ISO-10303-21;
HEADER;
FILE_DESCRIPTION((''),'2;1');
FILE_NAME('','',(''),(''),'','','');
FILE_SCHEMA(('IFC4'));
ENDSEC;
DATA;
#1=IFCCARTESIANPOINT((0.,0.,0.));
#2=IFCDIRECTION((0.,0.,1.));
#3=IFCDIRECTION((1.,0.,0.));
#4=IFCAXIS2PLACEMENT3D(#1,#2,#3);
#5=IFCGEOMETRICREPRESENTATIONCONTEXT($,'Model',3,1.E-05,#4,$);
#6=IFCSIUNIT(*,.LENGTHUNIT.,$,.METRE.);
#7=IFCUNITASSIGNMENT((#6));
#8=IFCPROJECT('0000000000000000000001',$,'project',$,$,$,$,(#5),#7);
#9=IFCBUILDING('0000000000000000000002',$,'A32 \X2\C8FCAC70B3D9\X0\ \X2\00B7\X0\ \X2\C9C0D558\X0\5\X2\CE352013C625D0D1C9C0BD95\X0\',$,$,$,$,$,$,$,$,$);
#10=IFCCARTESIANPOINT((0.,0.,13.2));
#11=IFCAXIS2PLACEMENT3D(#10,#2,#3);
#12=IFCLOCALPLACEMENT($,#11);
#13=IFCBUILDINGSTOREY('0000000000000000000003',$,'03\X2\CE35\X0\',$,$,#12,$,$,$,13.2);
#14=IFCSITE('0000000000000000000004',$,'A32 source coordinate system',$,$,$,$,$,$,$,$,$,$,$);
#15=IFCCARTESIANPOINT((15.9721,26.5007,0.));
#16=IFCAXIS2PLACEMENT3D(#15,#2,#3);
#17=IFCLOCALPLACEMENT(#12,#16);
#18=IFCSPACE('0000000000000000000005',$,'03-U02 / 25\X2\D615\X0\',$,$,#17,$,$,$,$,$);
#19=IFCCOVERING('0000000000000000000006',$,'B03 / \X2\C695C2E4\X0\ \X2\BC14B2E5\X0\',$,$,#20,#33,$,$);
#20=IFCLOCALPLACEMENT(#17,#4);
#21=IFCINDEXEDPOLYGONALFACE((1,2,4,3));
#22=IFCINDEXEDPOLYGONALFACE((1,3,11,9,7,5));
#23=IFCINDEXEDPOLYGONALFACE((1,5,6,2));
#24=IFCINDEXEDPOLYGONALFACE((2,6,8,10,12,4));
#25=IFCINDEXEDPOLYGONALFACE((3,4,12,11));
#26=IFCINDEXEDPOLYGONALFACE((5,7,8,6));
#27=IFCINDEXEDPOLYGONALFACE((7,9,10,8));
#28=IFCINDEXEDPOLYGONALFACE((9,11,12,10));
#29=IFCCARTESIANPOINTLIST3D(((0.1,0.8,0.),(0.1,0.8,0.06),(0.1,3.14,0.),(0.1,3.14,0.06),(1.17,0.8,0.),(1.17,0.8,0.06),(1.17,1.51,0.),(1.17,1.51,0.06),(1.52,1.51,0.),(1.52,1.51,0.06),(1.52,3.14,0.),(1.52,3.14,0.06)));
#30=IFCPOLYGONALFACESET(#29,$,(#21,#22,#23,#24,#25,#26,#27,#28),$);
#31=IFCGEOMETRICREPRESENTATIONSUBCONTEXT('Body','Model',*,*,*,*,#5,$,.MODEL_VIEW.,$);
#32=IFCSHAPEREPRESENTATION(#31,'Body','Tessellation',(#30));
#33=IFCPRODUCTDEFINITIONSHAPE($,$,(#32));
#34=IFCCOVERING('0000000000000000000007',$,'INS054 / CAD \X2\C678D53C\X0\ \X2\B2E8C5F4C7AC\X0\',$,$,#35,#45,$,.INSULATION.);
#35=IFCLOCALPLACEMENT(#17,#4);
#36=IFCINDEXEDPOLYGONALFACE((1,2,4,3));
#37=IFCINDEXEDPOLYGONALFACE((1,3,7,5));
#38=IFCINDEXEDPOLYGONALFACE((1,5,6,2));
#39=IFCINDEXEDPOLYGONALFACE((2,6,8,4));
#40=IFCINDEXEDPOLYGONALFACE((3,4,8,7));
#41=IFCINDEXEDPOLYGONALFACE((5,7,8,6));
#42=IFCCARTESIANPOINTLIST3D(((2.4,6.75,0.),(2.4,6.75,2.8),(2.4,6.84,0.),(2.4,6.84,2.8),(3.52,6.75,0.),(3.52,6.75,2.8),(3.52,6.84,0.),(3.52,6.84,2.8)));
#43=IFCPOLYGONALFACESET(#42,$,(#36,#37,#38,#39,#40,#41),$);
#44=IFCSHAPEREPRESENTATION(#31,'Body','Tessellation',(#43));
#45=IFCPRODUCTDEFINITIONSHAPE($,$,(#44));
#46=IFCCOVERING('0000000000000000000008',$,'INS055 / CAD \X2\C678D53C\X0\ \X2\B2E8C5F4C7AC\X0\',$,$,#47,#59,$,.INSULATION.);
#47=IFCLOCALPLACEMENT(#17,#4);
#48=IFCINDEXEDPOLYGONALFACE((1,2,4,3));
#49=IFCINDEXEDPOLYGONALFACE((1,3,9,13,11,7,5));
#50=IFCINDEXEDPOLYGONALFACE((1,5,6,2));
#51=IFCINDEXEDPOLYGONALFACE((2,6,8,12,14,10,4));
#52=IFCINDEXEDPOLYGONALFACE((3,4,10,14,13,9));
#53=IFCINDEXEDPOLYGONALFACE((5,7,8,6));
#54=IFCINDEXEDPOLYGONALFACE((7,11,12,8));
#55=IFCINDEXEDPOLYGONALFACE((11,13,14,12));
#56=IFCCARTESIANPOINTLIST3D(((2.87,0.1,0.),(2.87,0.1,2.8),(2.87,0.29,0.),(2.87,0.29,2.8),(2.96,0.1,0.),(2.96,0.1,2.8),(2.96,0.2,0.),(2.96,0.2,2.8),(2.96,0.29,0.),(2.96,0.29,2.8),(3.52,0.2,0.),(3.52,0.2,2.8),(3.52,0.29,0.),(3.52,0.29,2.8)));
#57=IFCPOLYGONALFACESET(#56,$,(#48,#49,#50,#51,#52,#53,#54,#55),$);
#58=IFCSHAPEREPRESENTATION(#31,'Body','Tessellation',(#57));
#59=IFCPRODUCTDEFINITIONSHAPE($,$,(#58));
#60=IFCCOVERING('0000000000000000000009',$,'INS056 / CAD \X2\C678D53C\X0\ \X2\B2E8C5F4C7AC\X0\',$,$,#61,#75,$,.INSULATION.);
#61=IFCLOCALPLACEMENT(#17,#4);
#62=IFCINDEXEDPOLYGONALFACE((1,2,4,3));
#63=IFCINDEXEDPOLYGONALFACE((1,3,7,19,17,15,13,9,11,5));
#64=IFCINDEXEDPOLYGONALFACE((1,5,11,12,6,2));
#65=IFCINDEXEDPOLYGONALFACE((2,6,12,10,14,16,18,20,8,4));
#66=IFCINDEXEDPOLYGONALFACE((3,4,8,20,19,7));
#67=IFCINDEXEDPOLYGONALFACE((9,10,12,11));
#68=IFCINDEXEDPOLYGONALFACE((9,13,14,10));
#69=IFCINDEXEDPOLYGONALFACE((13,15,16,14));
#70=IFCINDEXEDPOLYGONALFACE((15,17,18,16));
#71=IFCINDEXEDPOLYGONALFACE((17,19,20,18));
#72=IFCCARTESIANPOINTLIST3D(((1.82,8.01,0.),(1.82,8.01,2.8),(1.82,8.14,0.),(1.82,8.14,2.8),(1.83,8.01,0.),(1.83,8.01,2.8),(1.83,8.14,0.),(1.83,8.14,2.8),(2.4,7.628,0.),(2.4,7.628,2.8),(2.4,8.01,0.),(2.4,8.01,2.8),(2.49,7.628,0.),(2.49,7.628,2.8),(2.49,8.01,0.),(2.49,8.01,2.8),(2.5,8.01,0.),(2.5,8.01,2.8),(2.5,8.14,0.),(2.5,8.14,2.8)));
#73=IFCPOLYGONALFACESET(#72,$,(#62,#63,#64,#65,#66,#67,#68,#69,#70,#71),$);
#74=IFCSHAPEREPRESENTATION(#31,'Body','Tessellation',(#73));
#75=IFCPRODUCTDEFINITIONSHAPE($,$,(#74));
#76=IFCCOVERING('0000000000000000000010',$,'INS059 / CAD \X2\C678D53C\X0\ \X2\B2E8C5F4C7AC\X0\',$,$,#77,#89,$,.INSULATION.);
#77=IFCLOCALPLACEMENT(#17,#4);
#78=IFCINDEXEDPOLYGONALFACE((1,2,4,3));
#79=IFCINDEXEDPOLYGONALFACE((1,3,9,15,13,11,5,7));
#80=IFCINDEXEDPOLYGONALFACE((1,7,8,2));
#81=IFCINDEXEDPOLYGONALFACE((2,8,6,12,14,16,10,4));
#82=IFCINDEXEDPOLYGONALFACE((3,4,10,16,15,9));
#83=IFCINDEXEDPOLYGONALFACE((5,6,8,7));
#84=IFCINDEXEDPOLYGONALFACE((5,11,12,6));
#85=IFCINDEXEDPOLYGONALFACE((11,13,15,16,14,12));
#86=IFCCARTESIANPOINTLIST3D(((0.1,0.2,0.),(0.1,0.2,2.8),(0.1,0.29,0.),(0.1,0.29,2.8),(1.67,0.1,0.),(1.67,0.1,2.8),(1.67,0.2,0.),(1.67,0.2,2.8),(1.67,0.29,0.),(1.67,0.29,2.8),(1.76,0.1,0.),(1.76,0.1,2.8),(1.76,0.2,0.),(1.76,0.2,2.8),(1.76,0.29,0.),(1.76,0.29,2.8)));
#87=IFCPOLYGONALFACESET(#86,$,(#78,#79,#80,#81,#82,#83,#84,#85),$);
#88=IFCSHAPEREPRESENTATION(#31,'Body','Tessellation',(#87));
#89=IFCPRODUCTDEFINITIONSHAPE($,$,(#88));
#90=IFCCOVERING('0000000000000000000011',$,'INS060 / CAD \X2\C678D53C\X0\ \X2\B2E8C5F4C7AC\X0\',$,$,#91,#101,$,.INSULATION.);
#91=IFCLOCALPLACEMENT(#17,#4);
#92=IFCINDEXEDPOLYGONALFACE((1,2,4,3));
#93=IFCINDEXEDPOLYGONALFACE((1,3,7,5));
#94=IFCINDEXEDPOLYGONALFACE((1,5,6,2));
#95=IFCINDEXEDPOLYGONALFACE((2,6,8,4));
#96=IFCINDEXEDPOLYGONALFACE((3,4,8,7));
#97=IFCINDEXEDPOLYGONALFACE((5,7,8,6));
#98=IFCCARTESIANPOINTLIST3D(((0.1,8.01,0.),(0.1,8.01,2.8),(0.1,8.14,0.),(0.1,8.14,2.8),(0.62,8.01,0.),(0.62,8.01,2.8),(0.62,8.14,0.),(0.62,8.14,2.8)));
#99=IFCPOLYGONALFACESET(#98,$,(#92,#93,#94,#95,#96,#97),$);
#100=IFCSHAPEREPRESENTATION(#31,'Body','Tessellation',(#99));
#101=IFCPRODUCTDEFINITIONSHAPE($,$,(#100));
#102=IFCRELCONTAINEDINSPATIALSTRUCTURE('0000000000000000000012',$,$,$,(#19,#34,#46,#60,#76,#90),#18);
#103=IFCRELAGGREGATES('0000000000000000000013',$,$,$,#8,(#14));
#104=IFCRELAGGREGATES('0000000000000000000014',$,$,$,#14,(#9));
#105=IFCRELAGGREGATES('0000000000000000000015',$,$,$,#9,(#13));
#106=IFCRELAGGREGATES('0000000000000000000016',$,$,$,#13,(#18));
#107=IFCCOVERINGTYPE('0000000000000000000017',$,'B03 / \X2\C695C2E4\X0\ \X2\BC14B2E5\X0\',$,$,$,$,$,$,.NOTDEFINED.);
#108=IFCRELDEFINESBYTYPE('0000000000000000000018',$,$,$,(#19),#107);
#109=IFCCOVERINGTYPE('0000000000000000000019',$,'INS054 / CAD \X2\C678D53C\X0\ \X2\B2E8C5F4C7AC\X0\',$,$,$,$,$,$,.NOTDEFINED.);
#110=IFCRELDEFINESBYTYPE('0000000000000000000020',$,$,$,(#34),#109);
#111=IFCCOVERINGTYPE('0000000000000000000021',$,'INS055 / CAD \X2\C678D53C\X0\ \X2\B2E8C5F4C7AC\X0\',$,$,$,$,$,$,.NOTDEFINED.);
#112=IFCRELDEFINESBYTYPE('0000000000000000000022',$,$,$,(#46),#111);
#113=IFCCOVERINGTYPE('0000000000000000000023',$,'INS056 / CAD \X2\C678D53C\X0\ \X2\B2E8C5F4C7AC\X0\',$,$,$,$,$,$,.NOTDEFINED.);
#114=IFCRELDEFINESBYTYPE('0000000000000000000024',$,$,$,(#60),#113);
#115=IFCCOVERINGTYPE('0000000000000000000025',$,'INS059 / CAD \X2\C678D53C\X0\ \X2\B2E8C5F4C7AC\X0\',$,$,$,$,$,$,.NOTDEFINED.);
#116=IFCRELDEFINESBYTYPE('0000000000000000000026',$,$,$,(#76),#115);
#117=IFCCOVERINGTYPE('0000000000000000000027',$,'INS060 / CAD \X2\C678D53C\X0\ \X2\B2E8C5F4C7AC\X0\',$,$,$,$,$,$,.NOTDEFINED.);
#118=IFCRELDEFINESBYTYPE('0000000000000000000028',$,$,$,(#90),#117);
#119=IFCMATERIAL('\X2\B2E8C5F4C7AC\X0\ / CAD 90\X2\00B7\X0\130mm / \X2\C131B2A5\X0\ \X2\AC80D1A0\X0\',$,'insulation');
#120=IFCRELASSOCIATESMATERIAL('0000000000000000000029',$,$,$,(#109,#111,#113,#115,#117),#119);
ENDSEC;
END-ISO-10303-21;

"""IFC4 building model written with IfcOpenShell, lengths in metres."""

from ifc_helpers import new_model, si_unit, frame, origin, origin_with_axes, place, context, subcontext, project, spatial, polyline, outline, extrude, source, transform, mapped, material, type_object, type_shapes, element, save


model = new_model("IFC4")

# Units and contexts
model_context = context("Model", 3, precision=1e-05, world=origin_with_axes())
body_context = subcontext(model_context, "Body", "Model", "MODEL_VIEW")
ifc_project = project(units=[si_unit("LENGTHUNIT", "METRE")], contexts=[model_context])

# Site, building, storey, space
storey_placement = place(None, frame((0.0, 0.0, 13.2), z_axis=(0.0, 0.0, 1.0), x_axis=(1.0, 0.0, 0.0)))
space_placement = place(storey_placement, frame((15.9721, 26.5007, 0.0), z_axis=(0.0, 0.0, 1.0), x_axis=(1.0, 0.0, 0.0)))
site = spatial("IfcSite", under=ifc_project, Name="A32 source coordinate system")
building = spatial("IfcBuilding", under=site, Name="A32 주거동 · 지하5층–옥탑지붕")
storey = spatial("IfcBuildingStorey", under=building, at=storey_placement, Name="03층", Elevation=13.2)
space = spatial("IfcSpace", under=storey, at=space_placement, Name="03-U02 / 25형")

# Coverings
covering_type_1 = type_object("IfcCoveringType", Name="B03 / 욕실 바닥", PredefinedType="NOTDEFINED")
shared_shape_1 = source(origin(), body_context, "Body", "SweptSolid", [
    extrude(outline(polyline([(1.17, 1.51), (1.17, 0.8), (0.1, 0.8), (0.1, 3.14), (1.52, 3.14), (1.52, 1.51), (1.17, 1.51)])), origin(), (0.0, 0.0, 1.0), 0.06),
])
type_shapes(covering_type_1, [shared_shape_1])
covering_1_placement = place(space_placement, origin_with_axes())
element("IfcCovering", 1, at=covering_1_placement, inside=space, type_object=covering_type_1, Name="B03 / 욕실 바닥", context=body_context, shape_type="MappedRepresentation", body=[
    mapped(shared_shape_1, transform((0.0, 0.0, 0.0), scale=1.0)),
])
ifc_material = material(Name="단열재 / CAD 90·130mm / 성능 검토", Category="insulation")
covering_type_2 = type_object("IfcCoveringType", Name="INS054 / CAD 외피 단열재", PredefinedType="NOTDEFINED", material=ifc_material)
shared_shape_2 = source(origin(), body_context, "Body", "SweptSolid", [
    extrude(outline(polyline([(2.4, 6.84), (3.52, 6.84), (3.52, 6.75), (2.4, 6.75), (2.4, 6.84)])), origin(), (0.0, 0.0, 1.0), 2.8),
])
type_shapes(covering_type_2, [shared_shape_2])
covering_2_placement = place(space_placement, origin_with_axes())
element("IfcCovering", 2, at=covering_2_placement, inside=space, type_object=covering_type_2, Name="INS054 / CAD 외피 단열재", PredefinedType="INSULATION", context=body_context, shape_type="MappedRepresentation", body=[
    mapped(shared_shape_2, transform((0.0, 0.0, 0.0), scale=1.0)),
])
covering_type_3 = type_object("IfcCoveringType", Name="INS055 / CAD 외피 단열재", PredefinedType="NOTDEFINED", material=ifc_material)
shared_shape_3 = source(origin(), body_context, "Body", "SweptSolid", [
    extrude(outline(polyline([(2.87, 0.29), (2.96, 0.29), (3.52, 0.29), (3.52, 0.2), (2.96, 0.2), (2.96, 0.1), (2.87, 0.1), (2.87, 0.29)])), origin(), (0.0, 0.0, 1.0), 2.8),
])
type_shapes(covering_type_3, [shared_shape_3])
covering_3_placement = place(space_placement, origin_with_axes())
element("IfcCovering", 3, at=covering_3_placement, inside=space, type_object=covering_type_3, Name="INS055 / CAD 외피 단열재", PredefinedType="INSULATION", context=body_context, shape_type="MappedRepresentation", body=[
    mapped(shared_shape_3, transform((0.0, 0.0, 0.0), scale=1.0)),
])
covering_type_4 = type_object("IfcCoveringType", Name="INS056 / CAD 외피 단열재", PredefinedType="NOTDEFINED", material=ifc_material)
shared_shape_4 = source(origin(), body_context, "Body", "SweptSolid", [
    extrude(outline(polyline([(2.49, 7.628), (2.4, 7.628), (2.4, 8.01), (1.83, 8.01), (1.82, 8.01), (1.82, 8.14), (1.83, 8.14), (2.5, 8.14), (2.5, 8.01), (2.49, 8.01), (2.49, 7.628)])), origin(), (0.0, 0.0, 1.0), 2.8),
])
type_shapes(covering_type_4, [shared_shape_4])
covering_4_placement = place(space_placement, origin_with_axes())
element("IfcCovering", 4, at=covering_4_placement, inside=space, type_object=covering_type_4, Name="INS056 / CAD 외피 단열재", PredefinedType="INSULATION", context=body_context, shape_type="MappedRepresentation", body=[
    mapped(shared_shape_4, transform((0.0, 0.0, 0.0), scale=1.0)),
])
covering_type_5 = type_object("IfcCoveringType", Name="INS059 / CAD 외피 단열재", PredefinedType="NOTDEFINED", material=ifc_material)
shared_shape_5 = source(origin(), body_context, "Body", "SweptSolid", [
    extrude(outline(polyline([(1.76, 0.1), (1.67, 0.1), (1.67, 0.2), (0.1, 0.2), (0.1, 0.29), (1.67, 0.29), (1.76, 0.29), (1.76, 0.2), (1.76, 0.1)])), origin(), (0.0, 0.0, 1.0), 2.8),
])
type_shapes(covering_type_5, [shared_shape_5])
covering_5_placement = place(space_placement, origin_with_axes())
element("IfcCovering", 5, at=covering_5_placement, inside=space, type_object=covering_type_5, Name="INS059 / CAD 외피 단열재", PredefinedType="INSULATION", context=body_context, shape_type="MappedRepresentation", body=[
    mapped(shared_shape_5, transform((0.0, 0.0, 0.0), scale=1.0)),
])
covering_type_6 = type_object("IfcCoveringType", Name="INS060 / CAD 외피 단열재", PredefinedType="NOTDEFINED", material=ifc_material)
shared_shape_6 = source(origin(), body_context, "Body", "SweptSolid", [
    extrude(outline(polyline([(0.1, 8.01), (0.1, 8.14), (0.62, 8.14), (0.62, 8.01), (0.1, 8.01)])), origin(), (0.0, 0.0, 1.0), 2.8),
])
type_shapes(covering_type_6, [shared_shape_6])
covering_6_placement = place(space_placement, origin_with_axes())
element("IfcCovering", 6, at=covering_6_placement, inside=space, type_object=covering_type_6, Name="INS060 / CAD 외피 단열재", PredefinedType="INSULATION", context=body_context, shape_type="MappedRepresentation", body=[
    mapped(shared_shape_6, transform((0.0, 0.0, 0.0), scale=1.0)),
])

save(model, "model.ifc")
